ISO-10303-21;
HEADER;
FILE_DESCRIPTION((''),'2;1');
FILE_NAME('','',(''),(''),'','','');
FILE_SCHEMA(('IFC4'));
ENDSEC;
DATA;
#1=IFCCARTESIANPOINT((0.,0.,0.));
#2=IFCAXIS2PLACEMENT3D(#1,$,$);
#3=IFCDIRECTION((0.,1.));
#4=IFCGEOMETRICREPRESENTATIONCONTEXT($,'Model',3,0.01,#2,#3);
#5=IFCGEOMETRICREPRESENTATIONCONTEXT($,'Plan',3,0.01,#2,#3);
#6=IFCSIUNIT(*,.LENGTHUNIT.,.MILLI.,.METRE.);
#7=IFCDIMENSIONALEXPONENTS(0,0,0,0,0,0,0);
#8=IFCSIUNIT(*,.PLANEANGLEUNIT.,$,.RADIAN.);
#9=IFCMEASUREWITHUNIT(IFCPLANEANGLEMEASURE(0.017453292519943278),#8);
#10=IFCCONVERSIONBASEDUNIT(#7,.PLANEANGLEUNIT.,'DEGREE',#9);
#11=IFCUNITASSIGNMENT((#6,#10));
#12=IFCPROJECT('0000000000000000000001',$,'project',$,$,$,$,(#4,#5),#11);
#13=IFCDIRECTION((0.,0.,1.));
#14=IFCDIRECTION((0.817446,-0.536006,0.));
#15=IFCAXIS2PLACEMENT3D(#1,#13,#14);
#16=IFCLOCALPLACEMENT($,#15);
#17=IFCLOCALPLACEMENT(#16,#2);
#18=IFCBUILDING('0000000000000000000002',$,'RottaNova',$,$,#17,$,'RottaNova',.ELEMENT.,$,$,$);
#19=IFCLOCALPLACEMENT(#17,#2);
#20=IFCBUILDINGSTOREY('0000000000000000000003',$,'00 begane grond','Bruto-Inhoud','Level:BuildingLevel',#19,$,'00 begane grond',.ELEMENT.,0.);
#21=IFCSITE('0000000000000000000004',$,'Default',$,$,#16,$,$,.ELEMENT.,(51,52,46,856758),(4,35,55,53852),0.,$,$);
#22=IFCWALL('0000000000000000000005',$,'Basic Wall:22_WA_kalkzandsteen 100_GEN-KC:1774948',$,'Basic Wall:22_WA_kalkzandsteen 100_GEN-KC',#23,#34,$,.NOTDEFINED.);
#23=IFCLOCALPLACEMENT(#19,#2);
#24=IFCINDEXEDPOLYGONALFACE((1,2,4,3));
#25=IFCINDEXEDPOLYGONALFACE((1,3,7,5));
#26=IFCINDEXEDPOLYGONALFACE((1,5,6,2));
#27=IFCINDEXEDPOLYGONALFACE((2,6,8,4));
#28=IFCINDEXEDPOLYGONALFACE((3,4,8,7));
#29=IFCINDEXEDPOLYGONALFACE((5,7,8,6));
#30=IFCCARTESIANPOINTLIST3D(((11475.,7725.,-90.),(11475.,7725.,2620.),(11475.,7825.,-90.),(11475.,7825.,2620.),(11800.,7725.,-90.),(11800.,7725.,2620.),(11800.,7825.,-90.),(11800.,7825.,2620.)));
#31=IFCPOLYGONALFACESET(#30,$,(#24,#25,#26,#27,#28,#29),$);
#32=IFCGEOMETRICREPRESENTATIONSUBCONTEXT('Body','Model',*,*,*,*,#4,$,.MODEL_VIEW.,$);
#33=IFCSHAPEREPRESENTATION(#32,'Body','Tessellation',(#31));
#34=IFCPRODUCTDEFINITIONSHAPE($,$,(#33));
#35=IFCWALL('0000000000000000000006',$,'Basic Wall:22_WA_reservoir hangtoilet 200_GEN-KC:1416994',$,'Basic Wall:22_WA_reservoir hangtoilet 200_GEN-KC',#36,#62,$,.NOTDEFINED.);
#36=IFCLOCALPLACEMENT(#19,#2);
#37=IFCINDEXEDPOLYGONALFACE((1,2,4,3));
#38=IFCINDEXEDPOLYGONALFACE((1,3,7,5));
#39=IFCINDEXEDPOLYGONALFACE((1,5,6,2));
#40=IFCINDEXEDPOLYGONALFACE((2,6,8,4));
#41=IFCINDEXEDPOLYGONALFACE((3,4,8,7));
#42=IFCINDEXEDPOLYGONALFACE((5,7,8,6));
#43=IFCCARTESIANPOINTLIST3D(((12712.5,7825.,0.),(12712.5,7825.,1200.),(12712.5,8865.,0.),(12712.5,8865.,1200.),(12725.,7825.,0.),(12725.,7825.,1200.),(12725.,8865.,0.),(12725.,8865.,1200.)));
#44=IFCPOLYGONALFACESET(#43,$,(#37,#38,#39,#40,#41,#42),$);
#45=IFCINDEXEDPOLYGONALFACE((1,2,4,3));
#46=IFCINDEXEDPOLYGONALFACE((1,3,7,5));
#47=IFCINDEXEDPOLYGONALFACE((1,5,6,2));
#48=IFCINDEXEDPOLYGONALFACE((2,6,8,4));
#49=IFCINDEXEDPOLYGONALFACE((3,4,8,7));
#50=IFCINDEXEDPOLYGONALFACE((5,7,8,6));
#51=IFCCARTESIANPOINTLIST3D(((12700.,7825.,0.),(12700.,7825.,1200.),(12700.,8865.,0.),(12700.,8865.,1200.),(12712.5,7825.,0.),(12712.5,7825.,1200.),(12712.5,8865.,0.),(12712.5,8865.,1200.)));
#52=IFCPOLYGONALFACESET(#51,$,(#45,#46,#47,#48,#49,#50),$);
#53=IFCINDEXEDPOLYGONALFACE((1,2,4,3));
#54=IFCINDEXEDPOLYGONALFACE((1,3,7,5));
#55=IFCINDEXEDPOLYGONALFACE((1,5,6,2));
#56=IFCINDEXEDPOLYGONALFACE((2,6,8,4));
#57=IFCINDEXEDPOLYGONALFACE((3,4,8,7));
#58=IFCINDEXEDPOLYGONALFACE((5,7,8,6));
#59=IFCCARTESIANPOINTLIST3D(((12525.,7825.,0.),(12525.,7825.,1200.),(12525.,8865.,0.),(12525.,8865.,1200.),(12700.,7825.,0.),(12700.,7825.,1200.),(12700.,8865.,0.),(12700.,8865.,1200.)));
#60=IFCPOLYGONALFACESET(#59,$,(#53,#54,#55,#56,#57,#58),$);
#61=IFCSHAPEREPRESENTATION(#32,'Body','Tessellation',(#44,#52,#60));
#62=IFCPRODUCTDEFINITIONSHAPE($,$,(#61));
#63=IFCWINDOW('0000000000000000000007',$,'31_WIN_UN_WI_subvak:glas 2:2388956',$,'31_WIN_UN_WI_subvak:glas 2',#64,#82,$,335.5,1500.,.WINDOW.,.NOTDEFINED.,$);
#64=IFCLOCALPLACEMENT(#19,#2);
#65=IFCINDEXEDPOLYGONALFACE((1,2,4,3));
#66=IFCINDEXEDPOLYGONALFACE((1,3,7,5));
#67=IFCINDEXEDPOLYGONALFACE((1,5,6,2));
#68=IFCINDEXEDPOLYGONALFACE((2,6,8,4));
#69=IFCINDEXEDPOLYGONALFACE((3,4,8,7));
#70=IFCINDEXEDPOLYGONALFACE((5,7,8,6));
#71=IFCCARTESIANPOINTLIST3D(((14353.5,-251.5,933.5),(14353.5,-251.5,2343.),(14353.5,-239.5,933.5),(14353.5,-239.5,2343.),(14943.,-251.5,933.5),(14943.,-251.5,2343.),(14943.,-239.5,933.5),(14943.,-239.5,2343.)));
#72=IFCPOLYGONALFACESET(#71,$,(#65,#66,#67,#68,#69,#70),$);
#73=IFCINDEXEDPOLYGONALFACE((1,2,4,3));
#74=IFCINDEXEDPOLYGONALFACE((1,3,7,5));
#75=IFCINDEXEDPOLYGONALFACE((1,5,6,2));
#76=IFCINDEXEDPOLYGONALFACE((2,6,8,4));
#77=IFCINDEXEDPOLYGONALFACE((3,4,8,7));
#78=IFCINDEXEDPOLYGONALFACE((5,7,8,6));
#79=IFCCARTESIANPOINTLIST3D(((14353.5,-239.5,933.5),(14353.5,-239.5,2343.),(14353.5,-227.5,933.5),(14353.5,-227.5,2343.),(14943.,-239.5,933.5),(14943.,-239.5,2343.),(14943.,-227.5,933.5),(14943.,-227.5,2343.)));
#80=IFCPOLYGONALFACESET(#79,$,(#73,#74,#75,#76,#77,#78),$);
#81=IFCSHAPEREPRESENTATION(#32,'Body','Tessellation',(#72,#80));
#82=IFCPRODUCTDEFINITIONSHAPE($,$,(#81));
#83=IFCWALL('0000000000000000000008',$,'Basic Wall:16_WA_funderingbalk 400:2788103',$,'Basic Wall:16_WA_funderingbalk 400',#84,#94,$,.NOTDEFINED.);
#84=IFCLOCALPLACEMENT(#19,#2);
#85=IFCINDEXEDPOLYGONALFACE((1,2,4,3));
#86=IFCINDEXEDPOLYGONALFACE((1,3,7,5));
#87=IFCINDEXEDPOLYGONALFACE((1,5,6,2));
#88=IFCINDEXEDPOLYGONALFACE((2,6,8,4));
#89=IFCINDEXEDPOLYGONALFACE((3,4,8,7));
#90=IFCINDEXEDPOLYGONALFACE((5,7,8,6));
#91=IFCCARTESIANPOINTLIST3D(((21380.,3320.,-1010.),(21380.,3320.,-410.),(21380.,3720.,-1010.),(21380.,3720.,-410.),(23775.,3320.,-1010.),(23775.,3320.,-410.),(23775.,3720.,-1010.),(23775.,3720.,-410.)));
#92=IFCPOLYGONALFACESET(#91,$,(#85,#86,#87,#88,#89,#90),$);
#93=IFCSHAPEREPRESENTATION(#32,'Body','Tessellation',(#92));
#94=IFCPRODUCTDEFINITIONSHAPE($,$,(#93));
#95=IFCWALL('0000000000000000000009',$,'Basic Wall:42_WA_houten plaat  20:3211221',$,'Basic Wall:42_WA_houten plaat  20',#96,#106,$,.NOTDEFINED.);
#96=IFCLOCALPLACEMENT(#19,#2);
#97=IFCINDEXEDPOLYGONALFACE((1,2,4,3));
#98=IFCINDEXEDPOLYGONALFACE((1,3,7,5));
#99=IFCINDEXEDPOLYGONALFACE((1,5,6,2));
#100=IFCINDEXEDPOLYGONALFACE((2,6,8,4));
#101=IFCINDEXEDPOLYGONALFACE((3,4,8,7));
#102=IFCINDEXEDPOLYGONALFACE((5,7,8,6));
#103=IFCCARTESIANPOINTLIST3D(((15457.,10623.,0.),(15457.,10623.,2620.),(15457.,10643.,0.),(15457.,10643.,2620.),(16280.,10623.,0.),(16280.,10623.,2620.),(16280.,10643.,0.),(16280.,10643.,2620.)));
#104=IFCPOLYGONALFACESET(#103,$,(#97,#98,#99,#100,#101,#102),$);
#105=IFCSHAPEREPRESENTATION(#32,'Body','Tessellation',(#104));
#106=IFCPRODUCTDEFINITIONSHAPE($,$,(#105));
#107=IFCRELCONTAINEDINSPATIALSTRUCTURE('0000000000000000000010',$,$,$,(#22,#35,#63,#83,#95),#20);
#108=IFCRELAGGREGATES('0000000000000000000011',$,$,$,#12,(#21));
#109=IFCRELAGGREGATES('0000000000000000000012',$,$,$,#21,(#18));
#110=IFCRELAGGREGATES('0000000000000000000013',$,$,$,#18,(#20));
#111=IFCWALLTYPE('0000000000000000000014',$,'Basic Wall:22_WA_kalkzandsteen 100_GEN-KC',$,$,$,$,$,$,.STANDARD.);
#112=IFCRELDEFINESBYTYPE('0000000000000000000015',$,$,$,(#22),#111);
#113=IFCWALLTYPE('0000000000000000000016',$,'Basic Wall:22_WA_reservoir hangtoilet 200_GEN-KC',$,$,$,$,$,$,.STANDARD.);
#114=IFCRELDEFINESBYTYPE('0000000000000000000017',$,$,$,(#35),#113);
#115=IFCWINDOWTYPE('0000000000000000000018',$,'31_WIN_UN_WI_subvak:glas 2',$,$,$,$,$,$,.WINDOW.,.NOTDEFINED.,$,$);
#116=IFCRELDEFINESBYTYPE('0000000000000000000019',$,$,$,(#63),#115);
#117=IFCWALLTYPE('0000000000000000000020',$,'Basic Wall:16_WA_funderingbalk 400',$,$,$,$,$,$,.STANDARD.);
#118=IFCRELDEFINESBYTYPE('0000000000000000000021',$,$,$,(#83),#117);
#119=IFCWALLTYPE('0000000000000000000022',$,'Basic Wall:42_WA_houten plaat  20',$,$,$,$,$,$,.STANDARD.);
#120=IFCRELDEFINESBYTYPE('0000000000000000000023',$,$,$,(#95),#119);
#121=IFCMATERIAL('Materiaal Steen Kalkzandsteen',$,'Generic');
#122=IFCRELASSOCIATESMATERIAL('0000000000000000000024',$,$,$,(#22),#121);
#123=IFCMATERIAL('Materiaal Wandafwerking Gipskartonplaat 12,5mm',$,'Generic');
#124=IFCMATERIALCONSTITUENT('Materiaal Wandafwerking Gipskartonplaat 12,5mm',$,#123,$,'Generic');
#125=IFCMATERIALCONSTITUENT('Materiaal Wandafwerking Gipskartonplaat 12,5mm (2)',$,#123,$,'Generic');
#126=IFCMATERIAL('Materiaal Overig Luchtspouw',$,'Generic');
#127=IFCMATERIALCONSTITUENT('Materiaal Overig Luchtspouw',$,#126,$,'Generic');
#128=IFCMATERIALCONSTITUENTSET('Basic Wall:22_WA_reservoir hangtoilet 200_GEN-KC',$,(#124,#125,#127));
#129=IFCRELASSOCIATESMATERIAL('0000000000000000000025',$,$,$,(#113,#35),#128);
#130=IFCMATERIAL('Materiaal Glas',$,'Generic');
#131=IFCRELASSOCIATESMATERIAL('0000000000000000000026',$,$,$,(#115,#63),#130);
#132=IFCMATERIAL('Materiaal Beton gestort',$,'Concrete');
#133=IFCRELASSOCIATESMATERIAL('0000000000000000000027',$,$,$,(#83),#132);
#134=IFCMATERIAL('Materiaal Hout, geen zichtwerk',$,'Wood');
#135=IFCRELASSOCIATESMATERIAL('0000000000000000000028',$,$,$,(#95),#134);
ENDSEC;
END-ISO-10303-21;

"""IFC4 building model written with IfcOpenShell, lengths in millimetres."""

from ifc_helpers import new_model, entity, si_unit, converted_unit, direction, frame, origin, place, context, subcontext, project, spatial, indexed_curve, outline, extrude, source, transform, mapped, material, constituent, constituent_set, type_object, type_shapes, element, save


model = new_model("IFC4")

# Units and contexts
model_context = context("Model", 3, precision=0.01, world=origin(), true_north=direction((0.0, 1.0)))
plan_context = context("Plan", 3, precision=0.01, world=origin(), true_north=direction((0.0, 1.0)))
body_context = subcontext(model_context, "Body", "Model", "MODEL_VIEW")
ifc_project = project(units=[si_unit("LENGTHUNIT", "METRE", prefix="MILLI"), converted_unit("PLANEANGLEUNIT", "DEGREE", entity("IfcPlaneAngleMeasure", 0.017453292519943278), si_unit("PLANEANGLEUNIT", "RADIAN"), dimensions=[0, 0, 0, 0, 0, 0, 0])], contexts=[model_context, plan_context])

# Site, building, storey
site_placement = place(None, frame((0.0, 0.0, 0.0), z_axis=(0.0, 0.0, 1.0), x_axis=(0.817446, -0.536006, 0.0)))
site = spatial("IfcSite", under=ifc_project, at=site_placement, Name="Default", CompositionType="ELEMENT", RefLatitude=(51, 52, 46, 856758), RefLongitude=(4, 35, 55, 53852), RefElevation=0.0)
building_placement = place(site_placement, origin())
building = spatial("IfcBuilding", under=site, at=building_placement, Name="RottaNova", LongName="RottaNova", CompositionType="ELEMENT")
storey_placement = place(building_placement, origin())
storey = spatial("IfcBuildingStorey", under=building, at=storey_placement, Name="00 begane grond", Description="Bruto-Inhoud", ObjectType="Level:BuildingLevel", LongName="00 begane grond", CompositionType="ELEMENT", Elevation=0.0)

# Shared definitions
ifc_material_1 = material(Name="Materiaal Glas", Category="Generic")

# Walls
ifc_material_2 = material(Name="Materiaal Steen Kalkzandsteen", Category="Generic")
wall_type_1 = type_object("IfcWallType", Name="Basic Wall:22_WA_kalkzandsteen 100_GEN-KC", PredefinedType="STANDARD")
wall_1_placement = place(storey_placement, frame((11800.0, 7775.0, -90.0), z_axis=(0.0, 0.0, 1.0), x_axis=(-1.0, 0.0, 0.0)))
element("IfcWall", 1, at=wall_1_placement, inside=storey, type_object=wall_type_1, material=ifc_material_2, Name="Basic Wall:22_WA_kalkzandsteen 100_GEN-KC:1774948", ObjectType="Basic Wall:22_WA_kalkzandsteen 100_GEN-KC", PredefinedType="NOTDEFINED", context=body_context, shape_type="SweptSolid", body=[
    extrude(outline(indexed_curve([(325.0, 50.0), (0.0, 50.0), (0.0, -50.0), (325.0, -50.0), (325.0, 50.0)], self_intersect=False)), origin(), (0.0, 0.0, 1.0), 2710.0),
])
ifc_material_3 = material(Name="Materiaal Wandafwerking Gipskartonplaat 12,5mm", Category="Generic")
ifc_constituent_1 = constituent(ifc_material_3, Name="Materiaal Wandafwerking Gipskartonplaat 12,5mm", Category="Generic")
ifc_constituent_2 = constituent(ifc_material_3, Name="Materiaal Wandafwerking Gipskartonplaat 12,5mm (2)", Category="Generic")
ifc_material_4 = material(Name="Materiaal Overig Luchtspouw", Category="Generic")
ifc_constituent_3 = constituent(ifc_material_4, Name="Materiaal Overig Luchtspouw", Category="Generic")
ifc_constituent_set = constituent_set(constituents=[ifc_constituent_1, ifc_constituent_2, ifc_constituent_3], Name="Basic Wall:22_WA_reservoir hangtoilet 200_GEN-KC")
wall_type_2 = type_object("IfcWallType", Name="Basic Wall:22_WA_reservoir hangtoilet 200_GEN-KC", PredefinedType="STANDARD", material=ifc_constituent_set)
wall_2_placement = place(storey_placement, frame((12625.0, 8865.0, 0.0), z_axis=(0.0, 0.0, 1.0), x_axis=(0.0, -1.0, 0.0)))
element("IfcWall", 2, at=wall_2_placement, inside=storey, type_object=wall_type_2, material=ifc_constituent_set, Name="Basic Wall:22_WA_reservoir hangtoilet 200_GEN-KC:1416994", ObjectType="Basic Wall:22_WA_reservoir hangtoilet 200_GEN-KC", PredefinedType="NOTDEFINED", context=body_context, shape_type="SweptSolid", body=[
    extrude(outline(indexed_curve([(-6.3, -520.0), (6.2, -520.0), (6.3, 520.0), (-6.2, 520.0), (-6.3, -520.0)], self_intersect=False)), frame((520.0, 93.8, 0.0), z_axis=(0.0, 0.0, 1.0), x_axis=(0.0, -1.0, 0.0)), (0.0, 0.0, 1.0), 1200.0),
    extrude(outline(indexed_curve([(-520.0, -6.2), (520.0, -6.2), (520.0, 6.2), (-520.0, 6.2), (-520.0, -6.2)], self_intersect=False)), frame((520.0, 81.2, 0.0)), (0.0, 0.0, 1.0), 1200.0),
    extrude(outline(indexed_curve([(-87.5, -520.0), (87.5, -520.0), (87.5, 520.0), (-87.5, 520.0), (-87.5, -520.0)], self_intersect=False)), frame((520.0, -12.5, 0.0), z_axis=(0.0, 0.0, 1.0), x_axis=(0.0, 1.0, 0.0)), (0.0, 0.0, 1.0), 1200.0),
])

# Window
window_type = type_object("IfcWindowType", Name="31_WIN_UN_WI_subvak:glas 2", PartitioningType="NOTDEFINED", PredefinedType="WINDOW", material=ifc_material_1)
shared_shape_1 = source(origin(), body_context, "Body", "SweptSolid", [
    extrude(outline(indexed_curve([(-6.0, -294.7), (6.0, -294.7), (6.0, 294.7), (-6.0, 294.7), (-6.0, -294.7)], self_intersect=False)), frame((0.0, 6.0, 0.0), z_axis=(0.0, 0.0, 1.0), x_axis=(0.0, -1.0, 0.0)), (0.0, 0.0, 1.0), 1409.5),
    extrude(outline(indexed_curve([(-6.0, -294.8), (6.0, -294.8), (6.0, 294.8), (-6.0, 294.8), (-6.0, -294.8)], self_intersect=False)), frame((0.0, -6.0, 0.0), z_axis=(0.0, 0.0, 1.0), x_axis=(0.0, -1.0, 0.0)), (0.0, 0.0, 1.0), 1409.5),
])
type_shapes(window_type, [shared_shape_1])
window_1_placement = place(storey_placement, frame((14648.3, -239.5, 933.5), z_axis=(0.0, 0.0, 1.0), x_axis=(-1.0, 0.0, 0.0)))
element("IfcWindow", 3, at=window_1_placement, inside=storey, type_object=window_type, material=ifc_material_1, Name="31_WIN_UN_WI_subvak:glas 2:2388956", ObjectType="31_WIN_UN_WI_subvak:glas 2", OverallHeight=335.5, OverallWidth=1500.0, PartitioningType="NOTDEFINED", PredefinedType="WINDOW", context=body_context, shape_type="MappedRepresentation", body=[
    mapped(shared_shape_1, transform((0.0, 0.0, 0.0), scale=1.0)),
])

# Walls
ifc_material_5 = material(Name="Materiaal Beton gestort", Category="Concrete")
wall_type_3 = type_object("IfcWallType", Name="Basic Wall:16_WA_funderingbalk 400", PredefinedType="STANDARD")
wall_3_placement = place(storey_placement, frame((21380.0, 3520.0, -1010.0)))
element("IfcWall", 4, at=wall_3_placement, inside=storey, type_object=wall_type_3, material=ifc_material_5, Name="Basic Wall:16_WA_funderingbalk 400:2788103", ObjectType="Basic Wall:16_WA_funderingbalk 400", PredefinedType="NOTDEFINED", context=body_context, shape_type="SweptSolid", body=[
    extrude(outline(indexed_curve([(2395.0, 200.0), (0.0, 200.0), (0.0, -200.0), (2395.0, -200.0), (2395.0, 200.0)], self_intersect=False)), origin(), (0.0, 0.0, 1.0), 600.0),
])
ifc_material_6 = material(Name="Materiaal Hout, geen zichtwerk", Category="Wood")
wall_type_4 = type_object("IfcWallType", Name="Basic Wall:42_WA_houten plaat  20", PredefinedType="STANDARD")
wall_4_placement = place(storey_placement, frame((16280.0, 10633.0, 0.0), z_axis=(0.0, 0.0, 1.0), x_axis=(-1.0, 0.0, 0.0)))
element("IfcWall", 5, at=wall_4_placement, inside=storey, type_object=wall_type_4, material=ifc_material_6, Name="Basic Wall:42_WA_houten plaat  20:3211221", ObjectType="Basic Wall:42_WA_houten plaat  20", PredefinedType="NOTDEFINED", context=body_context, shape_type="SweptSolid", body=[
    extrude(outline(indexed_curve([(823.0, 10.0), (0.0, 10.0), (0.0, -10.0), (823.0, -10.0), (823.0, 10.0)], self_intersect=False)), origin(), (0.0, 0.0, 1.0), 2620.0),
])

save(model, "model.ifc")
